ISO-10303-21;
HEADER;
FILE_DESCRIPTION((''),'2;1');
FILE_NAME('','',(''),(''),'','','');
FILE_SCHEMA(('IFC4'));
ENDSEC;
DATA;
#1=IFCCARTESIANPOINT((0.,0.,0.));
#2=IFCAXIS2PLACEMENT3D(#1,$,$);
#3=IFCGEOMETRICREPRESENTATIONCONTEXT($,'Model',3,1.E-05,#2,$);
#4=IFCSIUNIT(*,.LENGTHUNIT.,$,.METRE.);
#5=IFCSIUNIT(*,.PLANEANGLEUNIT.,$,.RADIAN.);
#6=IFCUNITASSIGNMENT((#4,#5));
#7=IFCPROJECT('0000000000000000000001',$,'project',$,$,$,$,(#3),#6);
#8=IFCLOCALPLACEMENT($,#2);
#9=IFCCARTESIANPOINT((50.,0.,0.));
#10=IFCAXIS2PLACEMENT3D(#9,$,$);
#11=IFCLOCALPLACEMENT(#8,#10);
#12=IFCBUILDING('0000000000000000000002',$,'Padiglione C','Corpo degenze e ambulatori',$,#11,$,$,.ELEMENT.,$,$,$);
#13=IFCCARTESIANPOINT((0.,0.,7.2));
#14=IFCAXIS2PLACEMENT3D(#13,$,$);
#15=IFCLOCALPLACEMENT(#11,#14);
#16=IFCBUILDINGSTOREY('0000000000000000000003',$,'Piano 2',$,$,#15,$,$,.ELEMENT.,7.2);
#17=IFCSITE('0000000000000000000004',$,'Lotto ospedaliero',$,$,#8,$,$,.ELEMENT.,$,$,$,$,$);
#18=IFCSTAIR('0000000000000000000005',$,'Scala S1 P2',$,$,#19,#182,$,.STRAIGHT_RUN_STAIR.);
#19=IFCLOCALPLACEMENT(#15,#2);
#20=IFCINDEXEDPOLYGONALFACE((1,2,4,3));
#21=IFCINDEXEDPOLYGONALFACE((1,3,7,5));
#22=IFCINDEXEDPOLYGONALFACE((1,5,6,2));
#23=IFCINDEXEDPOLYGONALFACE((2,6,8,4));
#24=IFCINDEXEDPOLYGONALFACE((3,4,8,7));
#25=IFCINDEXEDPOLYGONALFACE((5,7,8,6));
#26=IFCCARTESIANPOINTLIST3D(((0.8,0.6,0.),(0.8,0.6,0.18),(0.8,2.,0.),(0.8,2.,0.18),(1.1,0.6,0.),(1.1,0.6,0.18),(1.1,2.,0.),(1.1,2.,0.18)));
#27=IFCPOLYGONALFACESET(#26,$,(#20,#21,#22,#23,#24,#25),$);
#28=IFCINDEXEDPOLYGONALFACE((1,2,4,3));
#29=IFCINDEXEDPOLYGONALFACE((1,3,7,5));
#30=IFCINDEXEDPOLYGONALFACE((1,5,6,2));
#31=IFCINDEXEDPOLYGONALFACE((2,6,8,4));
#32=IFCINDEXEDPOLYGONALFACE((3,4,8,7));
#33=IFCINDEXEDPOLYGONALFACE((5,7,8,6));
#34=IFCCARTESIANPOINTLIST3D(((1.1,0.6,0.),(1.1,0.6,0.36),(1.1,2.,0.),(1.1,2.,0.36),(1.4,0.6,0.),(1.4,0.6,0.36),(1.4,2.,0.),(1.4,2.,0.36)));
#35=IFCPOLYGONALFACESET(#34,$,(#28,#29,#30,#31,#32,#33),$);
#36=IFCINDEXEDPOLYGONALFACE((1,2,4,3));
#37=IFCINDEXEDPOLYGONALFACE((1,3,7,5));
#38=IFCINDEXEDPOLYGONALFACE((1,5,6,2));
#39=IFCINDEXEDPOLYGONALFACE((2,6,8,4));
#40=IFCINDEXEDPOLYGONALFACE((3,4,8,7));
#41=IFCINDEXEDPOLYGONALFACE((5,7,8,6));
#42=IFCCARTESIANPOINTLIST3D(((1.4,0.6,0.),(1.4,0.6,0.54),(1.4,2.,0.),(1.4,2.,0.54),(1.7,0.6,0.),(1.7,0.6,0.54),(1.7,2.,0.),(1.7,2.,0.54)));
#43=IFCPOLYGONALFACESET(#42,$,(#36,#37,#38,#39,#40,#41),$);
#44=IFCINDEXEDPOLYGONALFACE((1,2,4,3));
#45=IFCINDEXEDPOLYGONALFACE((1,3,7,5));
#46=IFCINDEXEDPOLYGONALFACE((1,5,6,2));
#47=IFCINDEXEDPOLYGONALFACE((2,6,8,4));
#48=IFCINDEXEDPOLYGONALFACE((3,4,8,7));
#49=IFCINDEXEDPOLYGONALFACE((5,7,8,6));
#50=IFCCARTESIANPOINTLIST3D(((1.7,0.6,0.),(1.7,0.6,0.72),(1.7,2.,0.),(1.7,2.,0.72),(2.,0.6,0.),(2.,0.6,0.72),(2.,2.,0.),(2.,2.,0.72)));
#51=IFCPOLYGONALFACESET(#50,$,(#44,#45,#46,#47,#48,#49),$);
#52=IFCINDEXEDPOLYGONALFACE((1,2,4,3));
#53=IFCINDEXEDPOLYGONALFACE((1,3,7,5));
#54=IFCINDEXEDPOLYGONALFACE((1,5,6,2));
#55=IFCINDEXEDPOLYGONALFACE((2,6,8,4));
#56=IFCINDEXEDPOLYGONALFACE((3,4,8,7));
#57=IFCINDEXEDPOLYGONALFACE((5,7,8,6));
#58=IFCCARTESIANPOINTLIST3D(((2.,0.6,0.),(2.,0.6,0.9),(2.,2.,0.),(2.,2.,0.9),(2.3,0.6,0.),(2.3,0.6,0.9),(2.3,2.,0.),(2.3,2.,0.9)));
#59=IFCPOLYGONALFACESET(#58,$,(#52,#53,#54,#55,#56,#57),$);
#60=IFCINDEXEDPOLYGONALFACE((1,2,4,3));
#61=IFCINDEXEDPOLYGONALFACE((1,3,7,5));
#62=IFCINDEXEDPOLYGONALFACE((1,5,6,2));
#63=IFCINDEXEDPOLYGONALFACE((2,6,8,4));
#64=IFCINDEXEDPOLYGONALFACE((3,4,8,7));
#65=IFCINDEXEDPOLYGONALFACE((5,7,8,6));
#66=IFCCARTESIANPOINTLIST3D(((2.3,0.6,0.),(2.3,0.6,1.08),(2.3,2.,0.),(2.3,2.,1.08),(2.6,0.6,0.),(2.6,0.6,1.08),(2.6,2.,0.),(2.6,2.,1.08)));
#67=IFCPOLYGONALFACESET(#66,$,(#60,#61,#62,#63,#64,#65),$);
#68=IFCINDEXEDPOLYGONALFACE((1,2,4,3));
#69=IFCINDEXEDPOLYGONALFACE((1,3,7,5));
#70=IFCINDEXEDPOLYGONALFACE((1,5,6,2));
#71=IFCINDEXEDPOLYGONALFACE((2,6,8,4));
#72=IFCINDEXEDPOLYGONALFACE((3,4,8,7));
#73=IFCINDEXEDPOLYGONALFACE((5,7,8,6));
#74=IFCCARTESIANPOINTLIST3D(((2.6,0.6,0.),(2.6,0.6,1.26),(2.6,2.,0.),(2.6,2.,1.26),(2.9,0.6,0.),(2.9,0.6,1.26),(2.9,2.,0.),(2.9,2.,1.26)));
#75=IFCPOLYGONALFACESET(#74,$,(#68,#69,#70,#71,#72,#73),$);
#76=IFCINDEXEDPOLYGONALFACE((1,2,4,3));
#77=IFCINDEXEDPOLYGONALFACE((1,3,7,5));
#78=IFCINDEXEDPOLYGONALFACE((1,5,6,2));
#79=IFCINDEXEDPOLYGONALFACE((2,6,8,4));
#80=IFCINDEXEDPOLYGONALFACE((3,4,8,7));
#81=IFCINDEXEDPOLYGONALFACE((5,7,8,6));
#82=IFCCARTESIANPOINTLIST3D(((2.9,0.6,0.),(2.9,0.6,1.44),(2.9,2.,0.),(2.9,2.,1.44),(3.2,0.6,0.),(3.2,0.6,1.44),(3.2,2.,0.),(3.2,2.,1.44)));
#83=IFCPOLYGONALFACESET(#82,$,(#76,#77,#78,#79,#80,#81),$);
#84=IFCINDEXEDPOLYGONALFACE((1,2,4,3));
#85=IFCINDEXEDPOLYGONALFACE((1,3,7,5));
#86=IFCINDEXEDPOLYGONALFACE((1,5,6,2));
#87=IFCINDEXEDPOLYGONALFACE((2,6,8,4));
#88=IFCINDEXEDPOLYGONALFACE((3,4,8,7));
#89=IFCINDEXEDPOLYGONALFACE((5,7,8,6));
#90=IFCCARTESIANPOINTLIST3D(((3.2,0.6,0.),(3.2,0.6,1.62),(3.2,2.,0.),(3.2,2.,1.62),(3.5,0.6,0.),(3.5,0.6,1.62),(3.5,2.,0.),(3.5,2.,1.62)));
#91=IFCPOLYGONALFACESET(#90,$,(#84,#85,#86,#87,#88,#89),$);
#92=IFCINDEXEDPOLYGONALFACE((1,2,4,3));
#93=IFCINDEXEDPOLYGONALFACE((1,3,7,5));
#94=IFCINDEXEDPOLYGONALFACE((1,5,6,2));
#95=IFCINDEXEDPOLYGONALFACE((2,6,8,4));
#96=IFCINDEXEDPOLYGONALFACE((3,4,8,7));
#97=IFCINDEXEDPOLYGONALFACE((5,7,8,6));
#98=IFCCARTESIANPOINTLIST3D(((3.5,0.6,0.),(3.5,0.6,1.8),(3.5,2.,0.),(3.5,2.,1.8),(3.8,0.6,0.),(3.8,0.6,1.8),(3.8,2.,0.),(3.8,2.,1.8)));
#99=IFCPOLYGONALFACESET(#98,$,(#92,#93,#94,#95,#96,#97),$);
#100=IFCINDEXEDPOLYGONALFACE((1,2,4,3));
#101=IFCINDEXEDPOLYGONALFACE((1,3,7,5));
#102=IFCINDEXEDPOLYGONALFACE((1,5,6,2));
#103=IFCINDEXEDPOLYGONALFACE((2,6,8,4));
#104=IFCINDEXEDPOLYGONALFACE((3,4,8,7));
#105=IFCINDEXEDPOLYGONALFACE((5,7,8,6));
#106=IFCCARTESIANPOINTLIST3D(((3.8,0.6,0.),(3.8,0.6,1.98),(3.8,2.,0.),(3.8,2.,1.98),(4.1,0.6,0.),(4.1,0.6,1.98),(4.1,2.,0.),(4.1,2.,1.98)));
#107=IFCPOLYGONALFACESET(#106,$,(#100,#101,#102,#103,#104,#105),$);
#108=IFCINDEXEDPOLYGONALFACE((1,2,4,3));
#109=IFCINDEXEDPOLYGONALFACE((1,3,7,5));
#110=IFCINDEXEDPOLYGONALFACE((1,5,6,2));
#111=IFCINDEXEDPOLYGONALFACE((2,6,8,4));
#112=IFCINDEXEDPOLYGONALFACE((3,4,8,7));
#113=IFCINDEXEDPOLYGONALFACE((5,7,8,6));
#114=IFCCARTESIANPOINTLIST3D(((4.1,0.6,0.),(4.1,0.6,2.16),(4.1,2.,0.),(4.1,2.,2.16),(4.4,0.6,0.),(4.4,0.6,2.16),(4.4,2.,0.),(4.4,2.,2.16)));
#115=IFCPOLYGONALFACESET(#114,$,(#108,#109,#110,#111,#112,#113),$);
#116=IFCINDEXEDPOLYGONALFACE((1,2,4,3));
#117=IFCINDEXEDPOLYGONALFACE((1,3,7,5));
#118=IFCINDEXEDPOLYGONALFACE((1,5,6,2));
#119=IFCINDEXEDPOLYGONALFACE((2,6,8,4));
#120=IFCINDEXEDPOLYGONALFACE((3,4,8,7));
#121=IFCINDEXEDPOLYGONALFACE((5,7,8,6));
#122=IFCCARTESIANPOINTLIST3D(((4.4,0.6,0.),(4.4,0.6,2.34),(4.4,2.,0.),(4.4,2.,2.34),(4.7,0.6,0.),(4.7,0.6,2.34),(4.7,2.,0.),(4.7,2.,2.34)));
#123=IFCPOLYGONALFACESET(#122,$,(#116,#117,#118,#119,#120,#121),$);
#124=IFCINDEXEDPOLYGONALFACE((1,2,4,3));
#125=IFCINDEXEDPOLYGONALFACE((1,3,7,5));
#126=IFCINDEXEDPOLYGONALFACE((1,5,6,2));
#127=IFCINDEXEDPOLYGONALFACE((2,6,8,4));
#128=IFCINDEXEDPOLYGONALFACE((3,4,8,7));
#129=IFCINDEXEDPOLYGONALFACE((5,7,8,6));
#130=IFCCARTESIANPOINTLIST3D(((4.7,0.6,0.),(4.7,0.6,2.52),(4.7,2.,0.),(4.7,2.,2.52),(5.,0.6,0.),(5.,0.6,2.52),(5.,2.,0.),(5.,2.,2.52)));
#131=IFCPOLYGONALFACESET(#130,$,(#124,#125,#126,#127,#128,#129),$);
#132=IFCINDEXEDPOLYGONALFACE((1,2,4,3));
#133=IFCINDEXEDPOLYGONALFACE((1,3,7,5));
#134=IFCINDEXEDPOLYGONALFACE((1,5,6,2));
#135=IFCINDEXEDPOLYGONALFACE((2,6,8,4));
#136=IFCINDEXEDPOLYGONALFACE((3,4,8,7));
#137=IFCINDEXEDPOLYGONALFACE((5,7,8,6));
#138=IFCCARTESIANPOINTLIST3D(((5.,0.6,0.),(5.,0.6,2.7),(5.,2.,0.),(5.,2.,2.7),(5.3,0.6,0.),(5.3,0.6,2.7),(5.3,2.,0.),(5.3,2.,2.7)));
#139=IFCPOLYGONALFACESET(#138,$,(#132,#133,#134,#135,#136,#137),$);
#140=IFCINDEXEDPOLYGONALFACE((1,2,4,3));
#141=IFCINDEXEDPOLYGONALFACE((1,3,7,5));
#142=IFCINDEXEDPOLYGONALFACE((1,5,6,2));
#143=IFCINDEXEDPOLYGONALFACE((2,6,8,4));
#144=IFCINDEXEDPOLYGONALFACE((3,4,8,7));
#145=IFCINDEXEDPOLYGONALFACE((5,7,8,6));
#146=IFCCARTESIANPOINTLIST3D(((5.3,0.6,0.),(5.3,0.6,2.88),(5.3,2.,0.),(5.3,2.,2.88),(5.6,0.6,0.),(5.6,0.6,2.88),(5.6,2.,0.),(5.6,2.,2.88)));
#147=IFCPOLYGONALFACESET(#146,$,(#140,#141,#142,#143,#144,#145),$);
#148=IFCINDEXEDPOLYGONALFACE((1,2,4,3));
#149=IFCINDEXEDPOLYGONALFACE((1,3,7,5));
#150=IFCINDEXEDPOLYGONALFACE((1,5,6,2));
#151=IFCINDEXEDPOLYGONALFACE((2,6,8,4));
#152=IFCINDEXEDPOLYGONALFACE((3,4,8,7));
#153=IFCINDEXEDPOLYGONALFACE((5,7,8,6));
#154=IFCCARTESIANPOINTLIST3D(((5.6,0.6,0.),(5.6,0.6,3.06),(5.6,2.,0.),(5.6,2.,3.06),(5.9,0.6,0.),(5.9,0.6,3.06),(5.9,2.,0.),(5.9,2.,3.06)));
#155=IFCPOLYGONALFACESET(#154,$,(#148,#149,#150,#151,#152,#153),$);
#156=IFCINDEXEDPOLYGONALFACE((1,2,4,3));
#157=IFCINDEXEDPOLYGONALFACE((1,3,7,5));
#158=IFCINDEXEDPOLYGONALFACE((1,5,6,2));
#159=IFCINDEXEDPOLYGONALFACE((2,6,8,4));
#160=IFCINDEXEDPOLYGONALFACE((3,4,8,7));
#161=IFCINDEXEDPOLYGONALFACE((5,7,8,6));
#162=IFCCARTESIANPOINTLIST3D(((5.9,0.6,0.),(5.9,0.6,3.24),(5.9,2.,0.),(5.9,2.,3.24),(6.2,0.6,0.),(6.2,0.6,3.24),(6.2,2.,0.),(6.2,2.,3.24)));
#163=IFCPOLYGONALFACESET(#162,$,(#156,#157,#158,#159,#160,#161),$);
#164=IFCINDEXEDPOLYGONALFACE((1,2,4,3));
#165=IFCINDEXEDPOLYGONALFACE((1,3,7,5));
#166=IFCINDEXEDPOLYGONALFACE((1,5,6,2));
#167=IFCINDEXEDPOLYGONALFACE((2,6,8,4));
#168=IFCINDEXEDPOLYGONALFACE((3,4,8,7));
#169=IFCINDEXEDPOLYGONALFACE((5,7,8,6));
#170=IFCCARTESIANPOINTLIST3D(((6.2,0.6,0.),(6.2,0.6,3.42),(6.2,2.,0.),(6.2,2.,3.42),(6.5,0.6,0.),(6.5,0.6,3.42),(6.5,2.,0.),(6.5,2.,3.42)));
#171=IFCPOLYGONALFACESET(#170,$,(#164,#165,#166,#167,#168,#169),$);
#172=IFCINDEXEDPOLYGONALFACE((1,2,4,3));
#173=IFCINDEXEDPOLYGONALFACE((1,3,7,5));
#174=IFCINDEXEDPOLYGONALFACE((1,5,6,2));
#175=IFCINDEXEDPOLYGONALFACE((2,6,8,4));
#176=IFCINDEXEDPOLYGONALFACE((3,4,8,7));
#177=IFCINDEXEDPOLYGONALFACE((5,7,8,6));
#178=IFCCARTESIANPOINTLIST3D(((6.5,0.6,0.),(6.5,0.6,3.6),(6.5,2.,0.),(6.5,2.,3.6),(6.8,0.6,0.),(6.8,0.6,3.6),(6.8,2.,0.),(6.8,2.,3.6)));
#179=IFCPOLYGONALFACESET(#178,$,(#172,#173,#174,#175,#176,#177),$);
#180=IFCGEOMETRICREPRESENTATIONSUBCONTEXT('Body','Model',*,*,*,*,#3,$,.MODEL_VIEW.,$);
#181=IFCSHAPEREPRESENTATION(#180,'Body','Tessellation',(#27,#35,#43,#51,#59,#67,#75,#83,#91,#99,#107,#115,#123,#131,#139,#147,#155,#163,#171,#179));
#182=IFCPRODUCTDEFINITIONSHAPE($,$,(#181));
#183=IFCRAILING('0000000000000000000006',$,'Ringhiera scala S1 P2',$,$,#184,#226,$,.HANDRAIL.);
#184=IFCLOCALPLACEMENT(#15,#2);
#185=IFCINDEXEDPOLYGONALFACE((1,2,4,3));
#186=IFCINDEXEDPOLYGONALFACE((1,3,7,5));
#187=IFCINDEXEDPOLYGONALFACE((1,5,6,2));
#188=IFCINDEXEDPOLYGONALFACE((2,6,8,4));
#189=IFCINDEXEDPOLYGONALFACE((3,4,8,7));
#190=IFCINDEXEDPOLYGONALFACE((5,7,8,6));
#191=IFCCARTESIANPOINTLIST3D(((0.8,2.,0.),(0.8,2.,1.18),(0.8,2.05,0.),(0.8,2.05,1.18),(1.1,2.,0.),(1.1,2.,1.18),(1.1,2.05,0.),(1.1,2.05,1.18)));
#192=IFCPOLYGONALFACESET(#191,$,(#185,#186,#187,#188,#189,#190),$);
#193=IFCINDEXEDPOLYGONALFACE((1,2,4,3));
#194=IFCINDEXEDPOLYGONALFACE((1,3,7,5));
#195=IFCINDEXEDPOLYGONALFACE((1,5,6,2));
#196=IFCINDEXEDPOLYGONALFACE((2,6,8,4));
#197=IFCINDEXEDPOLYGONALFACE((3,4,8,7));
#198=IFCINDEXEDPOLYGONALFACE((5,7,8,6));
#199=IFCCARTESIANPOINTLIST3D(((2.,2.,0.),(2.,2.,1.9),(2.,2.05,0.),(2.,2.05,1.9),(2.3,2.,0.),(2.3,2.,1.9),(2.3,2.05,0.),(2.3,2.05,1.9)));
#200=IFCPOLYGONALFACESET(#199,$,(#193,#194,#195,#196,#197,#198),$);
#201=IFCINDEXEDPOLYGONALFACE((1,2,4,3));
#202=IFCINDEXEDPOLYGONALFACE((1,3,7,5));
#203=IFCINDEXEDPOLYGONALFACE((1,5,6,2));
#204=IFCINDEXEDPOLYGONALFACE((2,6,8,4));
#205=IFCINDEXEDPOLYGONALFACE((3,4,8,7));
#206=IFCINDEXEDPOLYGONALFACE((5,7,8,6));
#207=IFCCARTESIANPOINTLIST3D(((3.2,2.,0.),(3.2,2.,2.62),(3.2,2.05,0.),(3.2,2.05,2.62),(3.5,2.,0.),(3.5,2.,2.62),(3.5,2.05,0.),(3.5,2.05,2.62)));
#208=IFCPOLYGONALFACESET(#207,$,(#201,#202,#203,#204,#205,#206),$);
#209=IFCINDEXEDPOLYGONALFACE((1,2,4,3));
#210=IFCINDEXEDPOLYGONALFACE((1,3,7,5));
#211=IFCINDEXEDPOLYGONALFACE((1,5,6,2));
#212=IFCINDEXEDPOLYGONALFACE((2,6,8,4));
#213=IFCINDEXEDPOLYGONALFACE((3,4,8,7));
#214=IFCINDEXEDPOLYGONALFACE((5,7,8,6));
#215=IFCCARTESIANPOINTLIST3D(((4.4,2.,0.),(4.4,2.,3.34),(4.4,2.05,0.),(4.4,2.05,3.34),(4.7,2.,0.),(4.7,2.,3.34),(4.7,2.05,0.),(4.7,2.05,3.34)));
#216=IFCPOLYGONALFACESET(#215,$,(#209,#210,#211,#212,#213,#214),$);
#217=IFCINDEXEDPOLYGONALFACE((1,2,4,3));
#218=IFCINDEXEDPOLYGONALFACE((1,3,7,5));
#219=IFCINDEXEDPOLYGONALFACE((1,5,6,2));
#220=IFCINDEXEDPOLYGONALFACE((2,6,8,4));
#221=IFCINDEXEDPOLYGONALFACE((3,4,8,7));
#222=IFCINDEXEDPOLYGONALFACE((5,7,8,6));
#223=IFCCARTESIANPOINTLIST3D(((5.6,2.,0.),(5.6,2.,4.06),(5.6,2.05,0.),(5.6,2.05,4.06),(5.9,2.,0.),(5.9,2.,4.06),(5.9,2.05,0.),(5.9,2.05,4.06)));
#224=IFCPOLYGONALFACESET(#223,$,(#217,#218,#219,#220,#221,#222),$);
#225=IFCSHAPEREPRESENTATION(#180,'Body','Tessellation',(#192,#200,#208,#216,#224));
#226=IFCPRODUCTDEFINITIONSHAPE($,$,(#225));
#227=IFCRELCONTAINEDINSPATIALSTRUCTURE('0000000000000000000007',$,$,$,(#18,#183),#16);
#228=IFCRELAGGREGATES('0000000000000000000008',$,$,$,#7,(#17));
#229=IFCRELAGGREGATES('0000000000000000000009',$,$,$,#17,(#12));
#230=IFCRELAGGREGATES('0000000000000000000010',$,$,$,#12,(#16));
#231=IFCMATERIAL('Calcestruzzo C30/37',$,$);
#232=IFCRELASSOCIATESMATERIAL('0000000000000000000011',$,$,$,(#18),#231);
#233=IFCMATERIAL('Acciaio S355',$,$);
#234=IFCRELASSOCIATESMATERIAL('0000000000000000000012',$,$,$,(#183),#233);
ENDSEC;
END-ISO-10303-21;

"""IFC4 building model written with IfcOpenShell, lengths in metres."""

from ifc_helpers import new_model, si_unit, frame, frame_2d, origin, place, context, subcontext, project, spatial, rectangle, extrude, material, element, save


model = new_model("IFC4")

# Units and contexts
model_context = context("Model", 3, precision=1e-05, world=origin())
body_context = subcontext(model_context, "Body", "Model", "MODEL_VIEW")
ifc_project = project(units=[si_unit("LENGTHUNIT", "METRE"), si_unit("PLANEANGLEUNIT", "RADIAN")], contexts=[model_context])

# Site, building, storey
site_placement = place(None, origin())
site = spatial("IfcSite", under=ifc_project, at=site_placement, Name="Lotto ospedaliero", CompositionType="ELEMENT")
building_placement = place(site_placement, frame((50.0, 0.0, 0.0)))
building = spatial("IfcBuilding", under=site, at=building_placement, Name="Padiglione C", Description="Corpo degenze e ambulatori", CompositionType="ELEMENT")
storey_placement = place(building_placement, frame((0.0, 0.0, 7.2)))
storey = spatial("IfcBuildingStorey", under=building, at=storey_placement, Name="Piano 2", CompositionType="ELEMENT", Elevation=7.2)

# Shared definitions
ifc_material_1 = material(Name="Calcestruzzo C30/37")

# Stair
stair_placement = place(storey_placement, frame((0.8, 0.6, 0.0)))
element("IfcStair", 1, at=stair_placement, inside=storey, material=ifc_material_1, Name="Scala S1 P2", PredefinedType="STRAIGHT_RUN_STAIR", context=body_context, shape_type="SweptSolid", body=[
    extrude(rectangle(XDim=0.3, YDim=1.4, at=frame_2d((0.15, 0.7))), origin(), (0.0, 0.0, 1.0), 0.18),
    extrude(rectangle(XDim=0.3, YDim=1.4, at=frame_2d((0.15, 0.7))), frame((0.3, 0.0, 0.0)), (0.0, 0.0, 1.0), 0.36),
    extrude(rectangle(XDim=0.3, YDim=1.4, at=frame_2d((0.15, 0.7))), frame((0.6, 0.0, 0.0)), (0.0, 0.0, 1.0), 0.54),
    extrude(rectangle(XDim=0.3, YDim=1.4, at=frame_2d((0.15, 0.7))), frame((0.9, 0.0, 0.0)), (0.0, 0.0, 1.0), 0.72),
    extrude(rectangle(XDim=0.3, YDim=1.4, at=frame_2d((0.15, 0.7))), frame((1.2, 0.0, 0.0)), (0.0, 0.0, 1.0), 0.9),
    extrude(rectangle(XDim=0.3, YDim=1.4, at=frame_2d((0.15, 0.7))), frame((1.5, 0.0, 0.0)), (0.0, 0.0, 1.0), 1.08),
    extrude(rectangle(XDim=0.3, YDim=1.4, at=frame_2d((0.15, 0.7))), frame((1.8, 0.0, 0.0)), (0.0, 0.0, 1.0), 1.26),
    extrude(rectangle(XDim=0.3, YDim=1.4, at=frame_2d((0.15, 0.7))), frame((2.1, 0.0, 0.0)), (0.0, 0.0, 1.0), 1.44),
    extrude(rectangle(XDim=0.3, YDim=1.4, at=frame_2d((0.15, 0.7))), frame((2.4, 0.0, 0.0)), (0.0, 0.0, 1.0), 1.62),
    extrude(rectangle(XDim=0.3, YDim=1.4, at=frame_2d((0.15, 0.7))), frame((2.7, 0.0, 0.0)), (0.0, 0.0, 1.0), 1.8),
    extrude(rectangle(XDim=0.3, YDim=1.4, at=frame_2d((0.15, 0.7))), frame((3.0, 0.0, 0.0)), (0.0, 0.0, 1.0), 1.98),
    extrude(rectangle(XDim=0.3, YDim=1.4, at=frame_2d((0.15, 0.7))), frame((3.3, 0.0, 0.0)), (0.0, 0.0, 1.0), 2.16),
    extrude(rectangle(XDim=0.3, YDim=1.4, at=frame_2d((0.15, 0.7))), frame((3.6, 0.0, 0.0)), (0.0, 0.0, 1.0), 2.34),
    extrude(rectangle(XDim=0.3, YDim=1.4, at=frame_2d((0.15, 0.7))), frame((3.9, 0.0, 0.0)), (0.0, 0.0, 1.0), 2.52),
    extrude(rectangle(XDim=0.3, YDim=1.4, at=frame_2d((0.15, 0.7))), frame((4.2, 0.0, 0.0)), (0.0, 0.0, 1.0), 2.7),
    extrude(rectangle(XDim=0.3, YDim=1.4, at=frame_2d((0.15, 0.7))), frame((4.5, 0.0, 0.0)), (0.0, 0.0, 1.0), 2.88),
    extrude(rectangle(XDim=0.3, YDim=1.4, at=frame_2d((0.15, 0.7))), frame((4.8, 0.0, 0.0)), (0.0, 0.0, 1.0), 3.06),
    extrude(rectangle(XDim=0.3, YDim=1.4, at=frame_2d((0.15, 0.7))), frame((5.1, 0.0, 0.0)), (0.0, 0.0, 1.0), 3.24),
    extrude(rectangle(XDim=0.3, YDim=1.4, at=frame_2d((0.15, 0.7))), frame((5.4, 0.0, 0.0)), (0.0, 0.0, 1.0), 3.42),
    extrude(rectangle(XDim=0.3, YDim=1.4, at=frame_2d((0.15, 0.7))), frame((5.7, 0.0, 0.0)), (0.0, 0.0, 1.0), 3.6),
])

# Railing
ifc_material_2 = material(Name="Acciaio S355")
railing_placement = place(storey_placement, frame((0.8, 2.0, 0.0)))
element("IfcRailing", 2, at=railing_placement, inside=storey, material=ifc_material_2, Name="Ringhiera scala S1 P2", PredefinedType="HANDRAIL", context=body_context, shape_type="SweptSolid", body=[
    extrude(rectangle(XDim=0.3, YDim=0.05, at=frame_2d((0.15, 0.025))), origin(), (0.0, 0.0, 1.0), 1.18),
    extrude(rectangle(XDim=0.3, YDim=0.05, at=frame_2d((0.15, 0.025))), frame((1.2, 0.0, 0.0)), (0.0, 0.0, 1.0), 1.9),
    extrude(rectangle(XDim=0.3, YDim=0.05, at=frame_2d((0.15, 0.025))), frame((2.4, 0.0, 0.0)), (0.0, 0.0, 1.0), 2.62),
    extrude(rectangle(XDim=0.3, YDim=0.05, at=frame_2d((0.15, 0.025))), frame((3.6, 0.0, 0.0)), (0.0, 0.0, 1.0), 3.34),
    extrude(rectangle(XDim=0.3, YDim=0.05, at=frame_2d((0.15, 0.025))), frame((4.8, 0.0, 0.0)), (0.0, 0.0, 1.0), 4.06),
])

save(model, "model.ifc")
